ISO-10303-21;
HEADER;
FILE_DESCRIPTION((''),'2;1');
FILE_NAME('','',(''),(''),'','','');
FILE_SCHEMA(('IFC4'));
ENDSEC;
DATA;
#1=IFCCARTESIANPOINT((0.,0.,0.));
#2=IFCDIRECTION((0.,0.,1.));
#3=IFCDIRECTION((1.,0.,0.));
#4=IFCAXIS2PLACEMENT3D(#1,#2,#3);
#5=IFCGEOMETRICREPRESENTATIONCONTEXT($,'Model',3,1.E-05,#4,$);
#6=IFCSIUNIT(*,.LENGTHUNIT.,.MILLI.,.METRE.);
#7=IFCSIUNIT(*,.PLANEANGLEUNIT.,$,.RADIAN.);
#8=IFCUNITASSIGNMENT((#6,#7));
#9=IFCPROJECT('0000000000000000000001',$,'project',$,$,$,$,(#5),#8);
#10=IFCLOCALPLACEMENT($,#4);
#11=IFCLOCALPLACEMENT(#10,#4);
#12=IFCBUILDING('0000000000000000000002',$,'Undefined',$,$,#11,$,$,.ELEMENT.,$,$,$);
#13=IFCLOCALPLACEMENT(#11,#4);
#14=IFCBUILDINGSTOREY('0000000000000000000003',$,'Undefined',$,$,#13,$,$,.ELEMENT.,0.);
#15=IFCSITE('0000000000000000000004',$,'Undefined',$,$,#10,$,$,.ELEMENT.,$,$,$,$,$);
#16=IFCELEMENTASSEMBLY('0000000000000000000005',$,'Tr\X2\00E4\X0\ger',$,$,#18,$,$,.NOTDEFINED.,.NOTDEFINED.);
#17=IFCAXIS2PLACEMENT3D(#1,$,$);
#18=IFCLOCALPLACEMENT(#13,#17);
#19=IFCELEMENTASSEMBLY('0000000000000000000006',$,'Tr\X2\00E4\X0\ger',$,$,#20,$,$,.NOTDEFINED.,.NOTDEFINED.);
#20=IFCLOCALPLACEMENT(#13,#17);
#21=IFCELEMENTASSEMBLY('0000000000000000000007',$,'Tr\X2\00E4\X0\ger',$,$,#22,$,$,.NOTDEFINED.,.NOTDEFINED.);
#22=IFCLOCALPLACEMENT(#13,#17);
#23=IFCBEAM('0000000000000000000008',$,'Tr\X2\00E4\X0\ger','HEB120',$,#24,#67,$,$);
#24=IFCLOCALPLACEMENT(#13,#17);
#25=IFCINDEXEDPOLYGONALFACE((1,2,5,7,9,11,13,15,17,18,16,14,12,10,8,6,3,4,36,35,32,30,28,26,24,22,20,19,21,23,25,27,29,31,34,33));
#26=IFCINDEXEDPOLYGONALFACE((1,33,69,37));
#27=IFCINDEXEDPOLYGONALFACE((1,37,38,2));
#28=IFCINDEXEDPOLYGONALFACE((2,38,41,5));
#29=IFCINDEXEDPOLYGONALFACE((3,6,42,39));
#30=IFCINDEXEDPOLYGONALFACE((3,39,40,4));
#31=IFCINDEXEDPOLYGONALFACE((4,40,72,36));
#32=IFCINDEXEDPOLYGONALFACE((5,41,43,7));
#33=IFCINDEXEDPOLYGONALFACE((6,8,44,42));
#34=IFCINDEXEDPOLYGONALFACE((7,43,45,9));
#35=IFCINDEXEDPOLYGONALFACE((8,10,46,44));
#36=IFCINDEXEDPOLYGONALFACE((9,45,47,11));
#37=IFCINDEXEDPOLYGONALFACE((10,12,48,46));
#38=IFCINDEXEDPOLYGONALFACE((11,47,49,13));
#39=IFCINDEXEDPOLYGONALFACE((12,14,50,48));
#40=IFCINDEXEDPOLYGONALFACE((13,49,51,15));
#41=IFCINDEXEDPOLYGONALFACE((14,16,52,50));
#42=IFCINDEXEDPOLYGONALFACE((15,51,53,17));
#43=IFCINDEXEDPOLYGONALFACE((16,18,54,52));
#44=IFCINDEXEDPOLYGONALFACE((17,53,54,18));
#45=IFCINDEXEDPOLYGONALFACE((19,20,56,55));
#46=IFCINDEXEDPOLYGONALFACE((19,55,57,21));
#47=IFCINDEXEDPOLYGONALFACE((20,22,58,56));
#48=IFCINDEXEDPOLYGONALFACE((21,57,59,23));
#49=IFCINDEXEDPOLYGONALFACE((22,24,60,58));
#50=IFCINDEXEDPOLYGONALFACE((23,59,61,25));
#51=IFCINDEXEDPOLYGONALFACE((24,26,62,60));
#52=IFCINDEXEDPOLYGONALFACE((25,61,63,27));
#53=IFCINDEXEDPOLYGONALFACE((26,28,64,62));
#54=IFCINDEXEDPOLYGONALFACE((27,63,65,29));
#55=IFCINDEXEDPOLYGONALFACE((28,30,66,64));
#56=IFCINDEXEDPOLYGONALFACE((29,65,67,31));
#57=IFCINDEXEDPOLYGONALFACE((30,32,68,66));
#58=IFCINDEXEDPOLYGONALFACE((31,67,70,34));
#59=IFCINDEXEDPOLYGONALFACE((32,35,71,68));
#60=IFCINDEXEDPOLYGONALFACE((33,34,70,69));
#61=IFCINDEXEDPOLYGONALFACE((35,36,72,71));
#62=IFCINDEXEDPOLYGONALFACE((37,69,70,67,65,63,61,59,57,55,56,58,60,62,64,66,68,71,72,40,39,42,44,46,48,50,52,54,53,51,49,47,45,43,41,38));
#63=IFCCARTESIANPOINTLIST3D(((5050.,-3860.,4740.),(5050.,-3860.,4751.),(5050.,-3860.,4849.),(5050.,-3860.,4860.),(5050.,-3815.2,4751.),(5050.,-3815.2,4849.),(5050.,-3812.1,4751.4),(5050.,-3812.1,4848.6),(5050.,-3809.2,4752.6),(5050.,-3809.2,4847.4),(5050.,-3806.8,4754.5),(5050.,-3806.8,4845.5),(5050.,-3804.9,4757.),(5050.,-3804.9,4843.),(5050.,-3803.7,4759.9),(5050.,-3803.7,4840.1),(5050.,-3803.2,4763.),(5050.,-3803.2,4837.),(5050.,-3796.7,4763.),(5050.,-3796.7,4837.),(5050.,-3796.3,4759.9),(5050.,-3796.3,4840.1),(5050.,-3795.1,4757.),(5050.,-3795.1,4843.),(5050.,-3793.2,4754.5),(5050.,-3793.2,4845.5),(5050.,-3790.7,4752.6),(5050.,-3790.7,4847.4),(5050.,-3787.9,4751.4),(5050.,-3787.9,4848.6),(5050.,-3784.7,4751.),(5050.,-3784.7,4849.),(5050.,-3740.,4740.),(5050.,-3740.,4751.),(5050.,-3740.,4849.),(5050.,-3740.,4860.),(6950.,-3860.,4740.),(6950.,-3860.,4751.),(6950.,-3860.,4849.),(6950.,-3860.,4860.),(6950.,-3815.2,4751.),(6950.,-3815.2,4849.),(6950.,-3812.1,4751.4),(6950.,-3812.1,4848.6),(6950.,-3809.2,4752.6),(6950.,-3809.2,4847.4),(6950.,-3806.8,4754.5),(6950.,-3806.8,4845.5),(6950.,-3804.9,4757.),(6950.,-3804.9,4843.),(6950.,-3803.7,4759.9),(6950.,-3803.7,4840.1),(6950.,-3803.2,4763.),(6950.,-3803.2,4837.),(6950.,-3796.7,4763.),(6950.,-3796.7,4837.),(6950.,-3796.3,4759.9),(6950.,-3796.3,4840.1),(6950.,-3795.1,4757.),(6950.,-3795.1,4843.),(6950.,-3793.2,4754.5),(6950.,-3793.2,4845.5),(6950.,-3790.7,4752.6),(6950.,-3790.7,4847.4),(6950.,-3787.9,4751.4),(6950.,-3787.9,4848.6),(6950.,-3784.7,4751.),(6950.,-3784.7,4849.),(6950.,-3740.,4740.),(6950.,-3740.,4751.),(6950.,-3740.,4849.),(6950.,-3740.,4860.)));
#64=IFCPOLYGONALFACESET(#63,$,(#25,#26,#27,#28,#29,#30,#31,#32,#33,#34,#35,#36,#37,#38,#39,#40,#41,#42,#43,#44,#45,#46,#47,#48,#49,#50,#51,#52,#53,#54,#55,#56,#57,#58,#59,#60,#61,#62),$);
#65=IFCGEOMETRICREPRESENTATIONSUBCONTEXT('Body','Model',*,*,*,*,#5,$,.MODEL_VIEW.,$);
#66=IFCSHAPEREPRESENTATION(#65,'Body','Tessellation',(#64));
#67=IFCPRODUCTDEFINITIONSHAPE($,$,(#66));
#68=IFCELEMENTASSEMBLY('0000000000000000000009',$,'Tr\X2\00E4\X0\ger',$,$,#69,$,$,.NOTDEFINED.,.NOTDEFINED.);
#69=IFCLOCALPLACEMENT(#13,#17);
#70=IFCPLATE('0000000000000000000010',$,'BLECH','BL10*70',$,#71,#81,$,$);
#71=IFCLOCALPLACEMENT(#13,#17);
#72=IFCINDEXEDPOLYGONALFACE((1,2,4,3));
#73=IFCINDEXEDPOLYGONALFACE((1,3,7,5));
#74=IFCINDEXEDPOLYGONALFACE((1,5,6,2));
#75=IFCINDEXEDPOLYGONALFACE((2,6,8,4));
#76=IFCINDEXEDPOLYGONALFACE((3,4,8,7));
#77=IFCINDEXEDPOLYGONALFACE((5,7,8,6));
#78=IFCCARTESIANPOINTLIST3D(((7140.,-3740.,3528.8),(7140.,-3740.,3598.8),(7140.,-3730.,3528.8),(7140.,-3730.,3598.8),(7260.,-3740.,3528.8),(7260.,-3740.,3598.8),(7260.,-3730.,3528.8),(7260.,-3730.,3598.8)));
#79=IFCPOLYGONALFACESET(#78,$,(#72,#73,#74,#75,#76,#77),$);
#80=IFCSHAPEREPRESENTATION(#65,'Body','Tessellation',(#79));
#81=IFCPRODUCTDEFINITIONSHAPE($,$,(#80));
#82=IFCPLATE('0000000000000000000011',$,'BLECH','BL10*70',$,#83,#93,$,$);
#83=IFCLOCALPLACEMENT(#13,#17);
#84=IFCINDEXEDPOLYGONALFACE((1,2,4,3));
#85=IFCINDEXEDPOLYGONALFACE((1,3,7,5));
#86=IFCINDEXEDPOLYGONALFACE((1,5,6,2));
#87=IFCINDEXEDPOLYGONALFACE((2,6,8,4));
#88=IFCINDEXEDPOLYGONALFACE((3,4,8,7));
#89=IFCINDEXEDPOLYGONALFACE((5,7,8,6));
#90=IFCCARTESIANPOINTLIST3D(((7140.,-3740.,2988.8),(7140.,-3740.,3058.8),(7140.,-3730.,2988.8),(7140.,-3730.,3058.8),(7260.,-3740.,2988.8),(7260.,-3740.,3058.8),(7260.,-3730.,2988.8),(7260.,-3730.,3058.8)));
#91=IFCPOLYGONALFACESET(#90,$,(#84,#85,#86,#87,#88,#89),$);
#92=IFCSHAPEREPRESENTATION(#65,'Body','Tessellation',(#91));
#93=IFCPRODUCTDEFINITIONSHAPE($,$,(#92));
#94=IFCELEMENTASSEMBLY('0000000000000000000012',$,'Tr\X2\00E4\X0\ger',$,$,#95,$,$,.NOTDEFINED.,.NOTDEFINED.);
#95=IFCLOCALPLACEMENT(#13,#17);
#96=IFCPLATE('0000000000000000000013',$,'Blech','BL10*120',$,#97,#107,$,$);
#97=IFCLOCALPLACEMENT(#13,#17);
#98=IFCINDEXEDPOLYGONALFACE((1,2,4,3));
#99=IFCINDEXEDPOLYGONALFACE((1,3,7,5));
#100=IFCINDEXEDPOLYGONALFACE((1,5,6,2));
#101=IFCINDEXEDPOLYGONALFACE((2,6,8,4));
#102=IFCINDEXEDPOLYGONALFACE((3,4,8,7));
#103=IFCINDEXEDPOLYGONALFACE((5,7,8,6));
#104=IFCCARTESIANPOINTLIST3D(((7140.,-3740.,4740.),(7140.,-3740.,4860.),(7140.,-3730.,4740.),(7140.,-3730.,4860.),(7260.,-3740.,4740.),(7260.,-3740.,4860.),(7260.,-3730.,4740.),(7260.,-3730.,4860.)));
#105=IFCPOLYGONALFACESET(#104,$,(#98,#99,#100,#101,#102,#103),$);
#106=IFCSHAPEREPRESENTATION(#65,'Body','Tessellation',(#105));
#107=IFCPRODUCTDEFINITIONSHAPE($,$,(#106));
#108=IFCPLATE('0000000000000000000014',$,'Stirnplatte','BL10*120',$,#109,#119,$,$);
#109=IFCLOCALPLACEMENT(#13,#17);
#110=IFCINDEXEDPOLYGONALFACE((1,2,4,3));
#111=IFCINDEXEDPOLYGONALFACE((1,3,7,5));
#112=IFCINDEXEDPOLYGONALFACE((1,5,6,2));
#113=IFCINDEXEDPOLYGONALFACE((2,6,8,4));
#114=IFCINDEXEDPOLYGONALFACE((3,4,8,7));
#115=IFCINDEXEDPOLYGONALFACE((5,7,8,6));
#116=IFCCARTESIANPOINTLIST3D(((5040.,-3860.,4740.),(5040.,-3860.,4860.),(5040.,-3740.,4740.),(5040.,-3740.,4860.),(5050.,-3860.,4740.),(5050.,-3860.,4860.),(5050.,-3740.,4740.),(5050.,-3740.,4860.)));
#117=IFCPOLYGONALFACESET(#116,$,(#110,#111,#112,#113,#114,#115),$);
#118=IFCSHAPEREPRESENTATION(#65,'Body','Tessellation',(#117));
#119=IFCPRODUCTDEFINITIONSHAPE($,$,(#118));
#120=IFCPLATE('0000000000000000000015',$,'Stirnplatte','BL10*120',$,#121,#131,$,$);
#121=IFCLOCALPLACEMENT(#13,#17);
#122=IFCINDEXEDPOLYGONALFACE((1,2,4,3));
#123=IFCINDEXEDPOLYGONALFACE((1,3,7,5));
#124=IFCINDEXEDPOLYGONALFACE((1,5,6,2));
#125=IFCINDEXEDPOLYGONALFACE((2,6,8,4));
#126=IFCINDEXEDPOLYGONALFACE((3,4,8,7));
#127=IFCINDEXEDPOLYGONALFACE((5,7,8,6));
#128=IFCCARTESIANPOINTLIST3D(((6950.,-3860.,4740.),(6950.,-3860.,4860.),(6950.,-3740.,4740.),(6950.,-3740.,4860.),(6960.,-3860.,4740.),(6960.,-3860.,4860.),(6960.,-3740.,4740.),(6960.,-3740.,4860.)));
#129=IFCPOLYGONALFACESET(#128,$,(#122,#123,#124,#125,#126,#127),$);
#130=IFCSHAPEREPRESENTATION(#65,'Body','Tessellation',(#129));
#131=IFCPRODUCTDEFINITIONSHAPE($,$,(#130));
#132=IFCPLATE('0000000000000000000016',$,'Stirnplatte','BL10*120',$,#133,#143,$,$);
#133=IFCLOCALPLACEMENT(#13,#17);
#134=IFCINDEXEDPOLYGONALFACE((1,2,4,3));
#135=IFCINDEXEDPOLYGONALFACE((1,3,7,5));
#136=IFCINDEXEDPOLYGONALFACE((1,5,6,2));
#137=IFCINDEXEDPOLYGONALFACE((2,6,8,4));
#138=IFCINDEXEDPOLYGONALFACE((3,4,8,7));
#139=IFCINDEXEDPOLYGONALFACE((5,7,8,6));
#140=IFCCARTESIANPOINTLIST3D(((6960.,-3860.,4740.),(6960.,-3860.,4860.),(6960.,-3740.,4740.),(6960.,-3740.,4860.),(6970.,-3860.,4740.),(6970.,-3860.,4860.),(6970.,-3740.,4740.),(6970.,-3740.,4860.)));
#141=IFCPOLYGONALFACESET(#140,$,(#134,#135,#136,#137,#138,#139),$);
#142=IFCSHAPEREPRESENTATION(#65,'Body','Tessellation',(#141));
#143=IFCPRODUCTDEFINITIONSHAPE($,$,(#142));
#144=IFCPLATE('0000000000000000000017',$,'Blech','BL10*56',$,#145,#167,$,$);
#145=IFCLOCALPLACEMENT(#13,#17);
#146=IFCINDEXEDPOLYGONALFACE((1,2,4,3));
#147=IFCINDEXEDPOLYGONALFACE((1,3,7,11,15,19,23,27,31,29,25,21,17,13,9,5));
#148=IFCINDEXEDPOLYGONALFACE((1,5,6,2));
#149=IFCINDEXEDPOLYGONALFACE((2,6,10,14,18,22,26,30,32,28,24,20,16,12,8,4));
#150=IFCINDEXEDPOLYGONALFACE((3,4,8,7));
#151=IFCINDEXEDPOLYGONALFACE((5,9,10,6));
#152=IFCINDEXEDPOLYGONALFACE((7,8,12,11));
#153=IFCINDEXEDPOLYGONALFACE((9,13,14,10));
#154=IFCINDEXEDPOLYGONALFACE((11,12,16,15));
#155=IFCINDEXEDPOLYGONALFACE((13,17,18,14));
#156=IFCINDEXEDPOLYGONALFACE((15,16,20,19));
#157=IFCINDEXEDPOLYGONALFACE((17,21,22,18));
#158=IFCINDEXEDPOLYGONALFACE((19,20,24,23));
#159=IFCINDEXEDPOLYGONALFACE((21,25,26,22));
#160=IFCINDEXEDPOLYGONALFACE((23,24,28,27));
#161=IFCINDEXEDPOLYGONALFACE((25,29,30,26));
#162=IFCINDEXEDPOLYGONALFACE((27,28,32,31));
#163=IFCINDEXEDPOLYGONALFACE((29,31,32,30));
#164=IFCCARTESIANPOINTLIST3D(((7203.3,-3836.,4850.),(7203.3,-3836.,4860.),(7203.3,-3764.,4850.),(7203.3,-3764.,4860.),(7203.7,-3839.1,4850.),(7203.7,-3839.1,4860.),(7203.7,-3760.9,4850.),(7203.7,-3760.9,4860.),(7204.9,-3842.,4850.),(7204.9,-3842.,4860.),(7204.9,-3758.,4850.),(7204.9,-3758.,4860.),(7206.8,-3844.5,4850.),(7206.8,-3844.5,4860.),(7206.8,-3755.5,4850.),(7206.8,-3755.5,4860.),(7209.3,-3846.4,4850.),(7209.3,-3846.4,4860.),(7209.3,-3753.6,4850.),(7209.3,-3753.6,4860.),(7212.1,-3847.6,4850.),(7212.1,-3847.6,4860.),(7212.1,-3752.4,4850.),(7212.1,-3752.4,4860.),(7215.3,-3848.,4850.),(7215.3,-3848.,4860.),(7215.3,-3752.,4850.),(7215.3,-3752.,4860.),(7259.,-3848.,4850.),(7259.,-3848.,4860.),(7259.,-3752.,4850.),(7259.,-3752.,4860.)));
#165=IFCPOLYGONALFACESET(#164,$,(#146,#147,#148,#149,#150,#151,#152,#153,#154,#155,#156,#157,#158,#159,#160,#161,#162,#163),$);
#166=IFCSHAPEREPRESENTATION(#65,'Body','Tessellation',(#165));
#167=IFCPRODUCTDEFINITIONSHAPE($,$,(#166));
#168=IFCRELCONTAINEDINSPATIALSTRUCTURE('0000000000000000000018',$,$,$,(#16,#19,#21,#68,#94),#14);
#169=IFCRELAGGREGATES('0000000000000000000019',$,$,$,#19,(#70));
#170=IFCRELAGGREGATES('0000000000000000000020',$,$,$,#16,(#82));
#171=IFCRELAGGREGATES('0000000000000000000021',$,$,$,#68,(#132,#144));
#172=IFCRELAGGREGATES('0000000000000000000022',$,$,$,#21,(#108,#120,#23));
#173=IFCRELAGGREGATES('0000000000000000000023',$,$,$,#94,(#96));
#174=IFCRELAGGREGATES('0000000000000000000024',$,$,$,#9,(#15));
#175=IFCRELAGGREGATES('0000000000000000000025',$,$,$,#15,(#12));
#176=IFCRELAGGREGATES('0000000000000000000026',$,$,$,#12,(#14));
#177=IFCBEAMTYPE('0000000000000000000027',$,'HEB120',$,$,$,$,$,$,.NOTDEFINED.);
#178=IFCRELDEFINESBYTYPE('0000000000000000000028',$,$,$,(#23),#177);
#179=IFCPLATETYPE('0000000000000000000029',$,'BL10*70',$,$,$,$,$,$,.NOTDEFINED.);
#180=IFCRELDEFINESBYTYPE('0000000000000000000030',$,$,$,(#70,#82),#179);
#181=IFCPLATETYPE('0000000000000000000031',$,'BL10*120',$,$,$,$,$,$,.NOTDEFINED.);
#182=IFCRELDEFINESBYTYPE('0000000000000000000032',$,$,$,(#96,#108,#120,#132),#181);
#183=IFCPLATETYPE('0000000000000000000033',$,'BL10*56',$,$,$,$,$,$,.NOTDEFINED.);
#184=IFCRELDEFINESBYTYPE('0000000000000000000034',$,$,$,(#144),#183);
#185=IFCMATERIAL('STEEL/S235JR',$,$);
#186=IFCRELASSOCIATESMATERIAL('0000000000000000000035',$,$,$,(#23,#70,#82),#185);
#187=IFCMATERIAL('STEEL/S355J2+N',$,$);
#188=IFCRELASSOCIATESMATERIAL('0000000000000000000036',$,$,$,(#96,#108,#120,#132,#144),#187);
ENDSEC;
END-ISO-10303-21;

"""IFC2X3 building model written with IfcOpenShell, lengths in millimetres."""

from ifc_helpers import new_model, si_unit, frame, frame_2d, origin_with_axes, origin_2d_with_axis, place, context, subcontext, project, spatial, polyline, circle_curve, parameter, trimmed, segment, composite_curve, i_section, outline, extrude, clip, halfspace, material, type_object, element, aggregate, save


model = new_model("IFC2X3")

# Units and contexts
model_context = context("Model", 3, precision=1e-05, world=origin_with_axes())
body_context = subcontext(model_context, "Body", "Model", "MODEL_VIEW")
ifc_project = project(units=[si_unit("LENGTHUNIT", "METRE", prefix="MILLI"), si_unit("PLANEANGLEUNIT", "RADIAN")], contexts=[model_context])

# Site, building, storey
site_placement = place(None, origin_with_axes())
site = spatial("IfcSite", under=ifc_project, at=site_placement, Name="Undefined", CompositionType="ELEMENT")
building_placement = place(site_placement, origin_with_axes())
building = spatial("IfcBuilding", under=site, at=building_placement, Name="Undefined", CompositionType="ELEMENT")
storey_placement = place(building_placement, origin_with_axes())
storey = spatial("IfcBuildingStorey", under=building, at=storey_placement, Name="Undefined", CompositionType="ELEMENT", Elevation=0.0)

# Element assemblies
assembly_1_placement = place(storey_placement, origin_with_axes())
assembly_1 = element("IfcElementAssembly", 1, at=assembly_1_placement, inside=storey, Name="Träger", AssemblyPlace="NOTDEFINED", PredefinedType="NOTDEFINED")
ifc_material_1 = material(Name="STEEL/S235JR")
assembly_2_placement = place(storey_placement, origin_with_axes())
assembly_2 = element("IfcElementAssembly", 2, at=assembly_2_placement, inside=storey, Name="Träger", AssemblyPlace="NOTDEFINED", PredefinedType="NOTDEFINED")

# Element assemblies, beam
beam_type_1 = type_object("IfcBeamType", Name="HEB120", PredefinedType="NOTDEFINED")
assembly_3_placement = place(storey_placement, origin_with_axes())
assembly_3 = element("IfcElementAssembly", 3, at=assembly_3_placement, inside=storey, Name="Träger", AssemblyPlace="NOTDEFINED", PredefinedType="NOTDEFINED")
beam_1_placement = place(assembly_3_placement, frame((6950.0, -3800.0, 4800.0), z_axis=(0.0, 0.0, 1.0), x_axis=(-1.0, 0.0, 0.0)))
beam_1 = element("IfcBeam", 4, at=beam_1_placement, type_object=beam_type_1, material=ifc_material_1, Name="Träger", Description="HEB120", context=body_context, shape_type="Clipping", body=[
    clip(clip(extrude(i_section(OverallWidth=120.0, OverallDepth=120.0, WebThickness=6.5, FlangeThickness=11.0, FilletRadius=12.0, at=origin_2d_with_axis()), frame((1910.0, 0.0, 0.0), z_axis=(-1.0, 0.0, 0.0), x_axis=(0.0, -1.0, 0.0)), (0.0, 0.0, 1.0), 1910.0), halfspace(frame((1900.0, 0.0, -60.0), z_axis=(-1.0, 0.0, 0.0), x_axis=(0.0, 1.0, 0.0)), True)), halfspace(frame((0.0, 0.0, -60.0), z_axis=(1.0, 0.0, 0.0), x_axis=(0.0, -1.0, 0.0)), True)),
])
assembly_4_placement = place(storey_placement, origin_with_axes())
assembly_4 = element("IfcElementAssembly", 5, at=assembly_4_placement, inside=storey, Name="Träger", AssemblyPlace="NOTDEFINED", PredefinedType="NOTDEFINED")

# Plates
plate_type_1 = type_object("IfcPlateType", Name="BL10*70", PredefinedType="NOTDEFINED")
plate_1_placement = place(assembly_2_placement, frame((7140.0, -3735.0, 3598.8), z_axis=(0.0, 1.0, 0.0), x_axis=(1.0, 0.0, 0.0)))
plate_1 = element("IfcPlate", 6, at=plate_1_placement, type_object=plate_type_1, material=ifc_material_1, Name="BLECH", Description="BL10*70", context=body_context, shape_type="SweptSolid", body=[
    extrude(outline(polyline([(0.0, 0.0), (120.0, 0.0), (120.0, 70.0), (0.0, 70.0), (0.0, 0.0)])), frame((0.0, 0.0, -5.0), z_axis=(0.0, 0.0, 1.0), x_axis=(1.0, 0.0, 0.0)), (0.0, 0.0, 1.0), 10.0),
])
aggregate(assembly_2, [plate_1])
plate_2_placement = place(assembly_1_placement, frame((7140.0, -3735.0, 3058.8), z_axis=(0.0, 1.0, 0.0), x_axis=(1.0, 0.0, 0.0)))
plate_2 = element("IfcPlate", 7, at=plate_2_placement, type_object=plate_type_1, material=ifc_material_1, Name="BLECH", Description="BL10*70", context=body_context, shape_type="SweptSolid", body=[
    extrude(outline(polyline([(0.0, 0.0), (120.0, 0.0), (120.0, 70.0), (0.0, 70.0), (0.0, 0.0)])), frame((0.0, 0.0, -5.0), z_axis=(0.0, 0.0, 1.0), x_axis=(1.0, 0.0, 0.0)), (0.0, 0.0, 1.0), 10.0),
])
aggregate(assembly_1, [plate_2])

# Element assembly, plate
assembly_5_placement = place(storey_placement, origin_with_axes())
assembly_5 = element("IfcElementAssembly", 8, at=assembly_5_placement, inside=storey, Name="Träger", AssemblyPlace="NOTDEFINED", PredefinedType="NOTDEFINED")
ifc_material_2 = material(Name="STEEL/S355J2+N")
plate_type_2 = type_object("IfcPlateType", Name="BL10*120", PredefinedType="NOTDEFINED")
plate_3_placement = place(assembly_5_placement, frame((7200.0, -3735.0, 4740.0), z_axis=(0.0, 1.0, 0.0), x_axis=(0.0, 0.0, 1.0)))
plate_3 = element("IfcPlate", 9, at=plate_3_placement, type_object=plate_type_2, material=ifc_material_2, Name="Blech", Description="BL10*120", context=body_context, shape_type="SweptSolid", body=[
    extrude(outline(polyline([(0.0, -60.0), (0.0, 60.0), (120.0, 60.0), (120.0, -60.0), (0.0, -60.0)])), frame((0.0, 0.0, -5.0), z_axis=(0.0, 0.0, 1.0), x_axis=(1.0, 0.0, 0.0)), (0.0, 0.0, 1.0), 10.0),
])

# Plates
plate_4_placement = place(assembly_3_placement, frame((5045.0, -3800.0, 4740.0), z_axis=(1.0, 0.0, 0.0), x_axis=(0.0, 0.0, 1.0)))
plate_4 = element("IfcPlate", 10, at=plate_4_placement, type_object=plate_type_2, material=ifc_material_2, Name="Stirnplatte", Description="BL10*120", context=body_context, shape_type="SweptSolid", body=[
    extrude(outline(polyline([(0.0, -60.0), (0.0, 60.0), (120.0, 60.0), (120.0, -60.0), (0.0, -60.0)])), frame((0.0, 0.0, -5.0), z_axis=(0.0, 0.0, 1.0), x_axis=(1.0, 0.0, 0.0)), (0.0, 0.0, 1.0), 10.0),
])
plate_5_placement = place(assembly_3_placement, frame((6955.0, -3800.0, 4740.0), z_axis=(-1.0, 0.0, 0.0), x_axis=(0.0, 0.0, 1.0)))
plate_5 = element("IfcPlate", 11, at=plate_5_placement, type_object=plate_type_2, material=ifc_material_2, Name="Stirnplatte", Description="BL10*120", context=body_context, shape_type="SweptSolid", body=[
    extrude(outline(polyline([(0.0, -60.0), (0.0, 60.0), (120.0, 60.0), (120.0, -60.0), (0.0, -60.0)])), frame((0.0, 0.0, -5.0), z_axis=(0.0, 0.0, 1.0), x_axis=(1.0, 0.0, 0.0)), (0.0, 0.0, 1.0), 10.0),
])
plate_6_placement = place(assembly_4_placement, frame((6965.0, -3800.0, 4740.0), z_axis=(-1.0, 0.0, 0.0), x_axis=(0.0, 0.0, 1.0)))
plate_6 = element("IfcPlate", 12, at=plate_6_placement, type_object=plate_type_2, material=ifc_material_2, Name="Stirnplatte", Description="BL10*120", context=body_context, shape_type="SweptSolid", body=[
    extrude(outline(polyline([(0.0, -60.0), (0.0, 60.0), (120.0, 60.0), (120.0, -60.0), (0.0, -60.0)])), frame((0.0, 0.0, -5.0), z_axis=(0.0, 0.0, 1.0), x_axis=(1.0, 0.0, 0.0)), (0.0, 0.0, 1.0), 10.0),
])
plate_type_3 = type_object("IfcPlateType", Name="BL10*56", PredefinedType="NOTDEFINED")
plate_7_placement = place(assembly_4_placement, frame((7203.3, -3848.0, 4855.0), z_axis=(0.0, 0.0, 1.0), x_axis=(1.0, 0.0, 0.0)))
plate_7 = element("IfcPlate", 13, at=plate_7_placement, type_object=plate_type_3, material=ifc_material_2, Name="Blech", Description="BL10*56", context=body_context, shape_type="SweptSolid", body=[
    extrude(outline(composite_curve([segment(trimmed(circle_curve(frame_2d((12.0, 12.0), x_axis=(-1.0, 0.0)), 12.0), [parameter(0.0)], [parameter(1.570796)], True, "PARAMETER"), True, "CONTINUOUS"), segment(polyline([(12.0, 0.0), (55.8, 0.0), (55.8, 96.0), (12.0, 96.0)]), True, "CONTINUOUS"), segment(trimmed(circle_curve(frame_2d((12.0, 84.0), x_axis=(0.0, 1.0)), 12.0), [parameter(0.0)], [parameter(1.570796)], True, "PARAMETER"), True, "CONTINUOUS"), segment(polyline([(0.0, 84.0), (0.0, 12.0)]), True, "CONTINUOUS")], self_intersect=True)), frame((0.0, 0.0, -5.0), z_axis=(0.0, 0.0, 1.0), x_axis=(1.0, 0.0, 0.0)), (0.0, 0.0, 1.0), 10.0),
])

aggregate(assembly_4, [plate_6, plate_7])

aggregate(assembly_3, [plate_4, plate_5, beam_1])

aggregate(assembly_5, [plate_3])

save(model, "model.ifc")
